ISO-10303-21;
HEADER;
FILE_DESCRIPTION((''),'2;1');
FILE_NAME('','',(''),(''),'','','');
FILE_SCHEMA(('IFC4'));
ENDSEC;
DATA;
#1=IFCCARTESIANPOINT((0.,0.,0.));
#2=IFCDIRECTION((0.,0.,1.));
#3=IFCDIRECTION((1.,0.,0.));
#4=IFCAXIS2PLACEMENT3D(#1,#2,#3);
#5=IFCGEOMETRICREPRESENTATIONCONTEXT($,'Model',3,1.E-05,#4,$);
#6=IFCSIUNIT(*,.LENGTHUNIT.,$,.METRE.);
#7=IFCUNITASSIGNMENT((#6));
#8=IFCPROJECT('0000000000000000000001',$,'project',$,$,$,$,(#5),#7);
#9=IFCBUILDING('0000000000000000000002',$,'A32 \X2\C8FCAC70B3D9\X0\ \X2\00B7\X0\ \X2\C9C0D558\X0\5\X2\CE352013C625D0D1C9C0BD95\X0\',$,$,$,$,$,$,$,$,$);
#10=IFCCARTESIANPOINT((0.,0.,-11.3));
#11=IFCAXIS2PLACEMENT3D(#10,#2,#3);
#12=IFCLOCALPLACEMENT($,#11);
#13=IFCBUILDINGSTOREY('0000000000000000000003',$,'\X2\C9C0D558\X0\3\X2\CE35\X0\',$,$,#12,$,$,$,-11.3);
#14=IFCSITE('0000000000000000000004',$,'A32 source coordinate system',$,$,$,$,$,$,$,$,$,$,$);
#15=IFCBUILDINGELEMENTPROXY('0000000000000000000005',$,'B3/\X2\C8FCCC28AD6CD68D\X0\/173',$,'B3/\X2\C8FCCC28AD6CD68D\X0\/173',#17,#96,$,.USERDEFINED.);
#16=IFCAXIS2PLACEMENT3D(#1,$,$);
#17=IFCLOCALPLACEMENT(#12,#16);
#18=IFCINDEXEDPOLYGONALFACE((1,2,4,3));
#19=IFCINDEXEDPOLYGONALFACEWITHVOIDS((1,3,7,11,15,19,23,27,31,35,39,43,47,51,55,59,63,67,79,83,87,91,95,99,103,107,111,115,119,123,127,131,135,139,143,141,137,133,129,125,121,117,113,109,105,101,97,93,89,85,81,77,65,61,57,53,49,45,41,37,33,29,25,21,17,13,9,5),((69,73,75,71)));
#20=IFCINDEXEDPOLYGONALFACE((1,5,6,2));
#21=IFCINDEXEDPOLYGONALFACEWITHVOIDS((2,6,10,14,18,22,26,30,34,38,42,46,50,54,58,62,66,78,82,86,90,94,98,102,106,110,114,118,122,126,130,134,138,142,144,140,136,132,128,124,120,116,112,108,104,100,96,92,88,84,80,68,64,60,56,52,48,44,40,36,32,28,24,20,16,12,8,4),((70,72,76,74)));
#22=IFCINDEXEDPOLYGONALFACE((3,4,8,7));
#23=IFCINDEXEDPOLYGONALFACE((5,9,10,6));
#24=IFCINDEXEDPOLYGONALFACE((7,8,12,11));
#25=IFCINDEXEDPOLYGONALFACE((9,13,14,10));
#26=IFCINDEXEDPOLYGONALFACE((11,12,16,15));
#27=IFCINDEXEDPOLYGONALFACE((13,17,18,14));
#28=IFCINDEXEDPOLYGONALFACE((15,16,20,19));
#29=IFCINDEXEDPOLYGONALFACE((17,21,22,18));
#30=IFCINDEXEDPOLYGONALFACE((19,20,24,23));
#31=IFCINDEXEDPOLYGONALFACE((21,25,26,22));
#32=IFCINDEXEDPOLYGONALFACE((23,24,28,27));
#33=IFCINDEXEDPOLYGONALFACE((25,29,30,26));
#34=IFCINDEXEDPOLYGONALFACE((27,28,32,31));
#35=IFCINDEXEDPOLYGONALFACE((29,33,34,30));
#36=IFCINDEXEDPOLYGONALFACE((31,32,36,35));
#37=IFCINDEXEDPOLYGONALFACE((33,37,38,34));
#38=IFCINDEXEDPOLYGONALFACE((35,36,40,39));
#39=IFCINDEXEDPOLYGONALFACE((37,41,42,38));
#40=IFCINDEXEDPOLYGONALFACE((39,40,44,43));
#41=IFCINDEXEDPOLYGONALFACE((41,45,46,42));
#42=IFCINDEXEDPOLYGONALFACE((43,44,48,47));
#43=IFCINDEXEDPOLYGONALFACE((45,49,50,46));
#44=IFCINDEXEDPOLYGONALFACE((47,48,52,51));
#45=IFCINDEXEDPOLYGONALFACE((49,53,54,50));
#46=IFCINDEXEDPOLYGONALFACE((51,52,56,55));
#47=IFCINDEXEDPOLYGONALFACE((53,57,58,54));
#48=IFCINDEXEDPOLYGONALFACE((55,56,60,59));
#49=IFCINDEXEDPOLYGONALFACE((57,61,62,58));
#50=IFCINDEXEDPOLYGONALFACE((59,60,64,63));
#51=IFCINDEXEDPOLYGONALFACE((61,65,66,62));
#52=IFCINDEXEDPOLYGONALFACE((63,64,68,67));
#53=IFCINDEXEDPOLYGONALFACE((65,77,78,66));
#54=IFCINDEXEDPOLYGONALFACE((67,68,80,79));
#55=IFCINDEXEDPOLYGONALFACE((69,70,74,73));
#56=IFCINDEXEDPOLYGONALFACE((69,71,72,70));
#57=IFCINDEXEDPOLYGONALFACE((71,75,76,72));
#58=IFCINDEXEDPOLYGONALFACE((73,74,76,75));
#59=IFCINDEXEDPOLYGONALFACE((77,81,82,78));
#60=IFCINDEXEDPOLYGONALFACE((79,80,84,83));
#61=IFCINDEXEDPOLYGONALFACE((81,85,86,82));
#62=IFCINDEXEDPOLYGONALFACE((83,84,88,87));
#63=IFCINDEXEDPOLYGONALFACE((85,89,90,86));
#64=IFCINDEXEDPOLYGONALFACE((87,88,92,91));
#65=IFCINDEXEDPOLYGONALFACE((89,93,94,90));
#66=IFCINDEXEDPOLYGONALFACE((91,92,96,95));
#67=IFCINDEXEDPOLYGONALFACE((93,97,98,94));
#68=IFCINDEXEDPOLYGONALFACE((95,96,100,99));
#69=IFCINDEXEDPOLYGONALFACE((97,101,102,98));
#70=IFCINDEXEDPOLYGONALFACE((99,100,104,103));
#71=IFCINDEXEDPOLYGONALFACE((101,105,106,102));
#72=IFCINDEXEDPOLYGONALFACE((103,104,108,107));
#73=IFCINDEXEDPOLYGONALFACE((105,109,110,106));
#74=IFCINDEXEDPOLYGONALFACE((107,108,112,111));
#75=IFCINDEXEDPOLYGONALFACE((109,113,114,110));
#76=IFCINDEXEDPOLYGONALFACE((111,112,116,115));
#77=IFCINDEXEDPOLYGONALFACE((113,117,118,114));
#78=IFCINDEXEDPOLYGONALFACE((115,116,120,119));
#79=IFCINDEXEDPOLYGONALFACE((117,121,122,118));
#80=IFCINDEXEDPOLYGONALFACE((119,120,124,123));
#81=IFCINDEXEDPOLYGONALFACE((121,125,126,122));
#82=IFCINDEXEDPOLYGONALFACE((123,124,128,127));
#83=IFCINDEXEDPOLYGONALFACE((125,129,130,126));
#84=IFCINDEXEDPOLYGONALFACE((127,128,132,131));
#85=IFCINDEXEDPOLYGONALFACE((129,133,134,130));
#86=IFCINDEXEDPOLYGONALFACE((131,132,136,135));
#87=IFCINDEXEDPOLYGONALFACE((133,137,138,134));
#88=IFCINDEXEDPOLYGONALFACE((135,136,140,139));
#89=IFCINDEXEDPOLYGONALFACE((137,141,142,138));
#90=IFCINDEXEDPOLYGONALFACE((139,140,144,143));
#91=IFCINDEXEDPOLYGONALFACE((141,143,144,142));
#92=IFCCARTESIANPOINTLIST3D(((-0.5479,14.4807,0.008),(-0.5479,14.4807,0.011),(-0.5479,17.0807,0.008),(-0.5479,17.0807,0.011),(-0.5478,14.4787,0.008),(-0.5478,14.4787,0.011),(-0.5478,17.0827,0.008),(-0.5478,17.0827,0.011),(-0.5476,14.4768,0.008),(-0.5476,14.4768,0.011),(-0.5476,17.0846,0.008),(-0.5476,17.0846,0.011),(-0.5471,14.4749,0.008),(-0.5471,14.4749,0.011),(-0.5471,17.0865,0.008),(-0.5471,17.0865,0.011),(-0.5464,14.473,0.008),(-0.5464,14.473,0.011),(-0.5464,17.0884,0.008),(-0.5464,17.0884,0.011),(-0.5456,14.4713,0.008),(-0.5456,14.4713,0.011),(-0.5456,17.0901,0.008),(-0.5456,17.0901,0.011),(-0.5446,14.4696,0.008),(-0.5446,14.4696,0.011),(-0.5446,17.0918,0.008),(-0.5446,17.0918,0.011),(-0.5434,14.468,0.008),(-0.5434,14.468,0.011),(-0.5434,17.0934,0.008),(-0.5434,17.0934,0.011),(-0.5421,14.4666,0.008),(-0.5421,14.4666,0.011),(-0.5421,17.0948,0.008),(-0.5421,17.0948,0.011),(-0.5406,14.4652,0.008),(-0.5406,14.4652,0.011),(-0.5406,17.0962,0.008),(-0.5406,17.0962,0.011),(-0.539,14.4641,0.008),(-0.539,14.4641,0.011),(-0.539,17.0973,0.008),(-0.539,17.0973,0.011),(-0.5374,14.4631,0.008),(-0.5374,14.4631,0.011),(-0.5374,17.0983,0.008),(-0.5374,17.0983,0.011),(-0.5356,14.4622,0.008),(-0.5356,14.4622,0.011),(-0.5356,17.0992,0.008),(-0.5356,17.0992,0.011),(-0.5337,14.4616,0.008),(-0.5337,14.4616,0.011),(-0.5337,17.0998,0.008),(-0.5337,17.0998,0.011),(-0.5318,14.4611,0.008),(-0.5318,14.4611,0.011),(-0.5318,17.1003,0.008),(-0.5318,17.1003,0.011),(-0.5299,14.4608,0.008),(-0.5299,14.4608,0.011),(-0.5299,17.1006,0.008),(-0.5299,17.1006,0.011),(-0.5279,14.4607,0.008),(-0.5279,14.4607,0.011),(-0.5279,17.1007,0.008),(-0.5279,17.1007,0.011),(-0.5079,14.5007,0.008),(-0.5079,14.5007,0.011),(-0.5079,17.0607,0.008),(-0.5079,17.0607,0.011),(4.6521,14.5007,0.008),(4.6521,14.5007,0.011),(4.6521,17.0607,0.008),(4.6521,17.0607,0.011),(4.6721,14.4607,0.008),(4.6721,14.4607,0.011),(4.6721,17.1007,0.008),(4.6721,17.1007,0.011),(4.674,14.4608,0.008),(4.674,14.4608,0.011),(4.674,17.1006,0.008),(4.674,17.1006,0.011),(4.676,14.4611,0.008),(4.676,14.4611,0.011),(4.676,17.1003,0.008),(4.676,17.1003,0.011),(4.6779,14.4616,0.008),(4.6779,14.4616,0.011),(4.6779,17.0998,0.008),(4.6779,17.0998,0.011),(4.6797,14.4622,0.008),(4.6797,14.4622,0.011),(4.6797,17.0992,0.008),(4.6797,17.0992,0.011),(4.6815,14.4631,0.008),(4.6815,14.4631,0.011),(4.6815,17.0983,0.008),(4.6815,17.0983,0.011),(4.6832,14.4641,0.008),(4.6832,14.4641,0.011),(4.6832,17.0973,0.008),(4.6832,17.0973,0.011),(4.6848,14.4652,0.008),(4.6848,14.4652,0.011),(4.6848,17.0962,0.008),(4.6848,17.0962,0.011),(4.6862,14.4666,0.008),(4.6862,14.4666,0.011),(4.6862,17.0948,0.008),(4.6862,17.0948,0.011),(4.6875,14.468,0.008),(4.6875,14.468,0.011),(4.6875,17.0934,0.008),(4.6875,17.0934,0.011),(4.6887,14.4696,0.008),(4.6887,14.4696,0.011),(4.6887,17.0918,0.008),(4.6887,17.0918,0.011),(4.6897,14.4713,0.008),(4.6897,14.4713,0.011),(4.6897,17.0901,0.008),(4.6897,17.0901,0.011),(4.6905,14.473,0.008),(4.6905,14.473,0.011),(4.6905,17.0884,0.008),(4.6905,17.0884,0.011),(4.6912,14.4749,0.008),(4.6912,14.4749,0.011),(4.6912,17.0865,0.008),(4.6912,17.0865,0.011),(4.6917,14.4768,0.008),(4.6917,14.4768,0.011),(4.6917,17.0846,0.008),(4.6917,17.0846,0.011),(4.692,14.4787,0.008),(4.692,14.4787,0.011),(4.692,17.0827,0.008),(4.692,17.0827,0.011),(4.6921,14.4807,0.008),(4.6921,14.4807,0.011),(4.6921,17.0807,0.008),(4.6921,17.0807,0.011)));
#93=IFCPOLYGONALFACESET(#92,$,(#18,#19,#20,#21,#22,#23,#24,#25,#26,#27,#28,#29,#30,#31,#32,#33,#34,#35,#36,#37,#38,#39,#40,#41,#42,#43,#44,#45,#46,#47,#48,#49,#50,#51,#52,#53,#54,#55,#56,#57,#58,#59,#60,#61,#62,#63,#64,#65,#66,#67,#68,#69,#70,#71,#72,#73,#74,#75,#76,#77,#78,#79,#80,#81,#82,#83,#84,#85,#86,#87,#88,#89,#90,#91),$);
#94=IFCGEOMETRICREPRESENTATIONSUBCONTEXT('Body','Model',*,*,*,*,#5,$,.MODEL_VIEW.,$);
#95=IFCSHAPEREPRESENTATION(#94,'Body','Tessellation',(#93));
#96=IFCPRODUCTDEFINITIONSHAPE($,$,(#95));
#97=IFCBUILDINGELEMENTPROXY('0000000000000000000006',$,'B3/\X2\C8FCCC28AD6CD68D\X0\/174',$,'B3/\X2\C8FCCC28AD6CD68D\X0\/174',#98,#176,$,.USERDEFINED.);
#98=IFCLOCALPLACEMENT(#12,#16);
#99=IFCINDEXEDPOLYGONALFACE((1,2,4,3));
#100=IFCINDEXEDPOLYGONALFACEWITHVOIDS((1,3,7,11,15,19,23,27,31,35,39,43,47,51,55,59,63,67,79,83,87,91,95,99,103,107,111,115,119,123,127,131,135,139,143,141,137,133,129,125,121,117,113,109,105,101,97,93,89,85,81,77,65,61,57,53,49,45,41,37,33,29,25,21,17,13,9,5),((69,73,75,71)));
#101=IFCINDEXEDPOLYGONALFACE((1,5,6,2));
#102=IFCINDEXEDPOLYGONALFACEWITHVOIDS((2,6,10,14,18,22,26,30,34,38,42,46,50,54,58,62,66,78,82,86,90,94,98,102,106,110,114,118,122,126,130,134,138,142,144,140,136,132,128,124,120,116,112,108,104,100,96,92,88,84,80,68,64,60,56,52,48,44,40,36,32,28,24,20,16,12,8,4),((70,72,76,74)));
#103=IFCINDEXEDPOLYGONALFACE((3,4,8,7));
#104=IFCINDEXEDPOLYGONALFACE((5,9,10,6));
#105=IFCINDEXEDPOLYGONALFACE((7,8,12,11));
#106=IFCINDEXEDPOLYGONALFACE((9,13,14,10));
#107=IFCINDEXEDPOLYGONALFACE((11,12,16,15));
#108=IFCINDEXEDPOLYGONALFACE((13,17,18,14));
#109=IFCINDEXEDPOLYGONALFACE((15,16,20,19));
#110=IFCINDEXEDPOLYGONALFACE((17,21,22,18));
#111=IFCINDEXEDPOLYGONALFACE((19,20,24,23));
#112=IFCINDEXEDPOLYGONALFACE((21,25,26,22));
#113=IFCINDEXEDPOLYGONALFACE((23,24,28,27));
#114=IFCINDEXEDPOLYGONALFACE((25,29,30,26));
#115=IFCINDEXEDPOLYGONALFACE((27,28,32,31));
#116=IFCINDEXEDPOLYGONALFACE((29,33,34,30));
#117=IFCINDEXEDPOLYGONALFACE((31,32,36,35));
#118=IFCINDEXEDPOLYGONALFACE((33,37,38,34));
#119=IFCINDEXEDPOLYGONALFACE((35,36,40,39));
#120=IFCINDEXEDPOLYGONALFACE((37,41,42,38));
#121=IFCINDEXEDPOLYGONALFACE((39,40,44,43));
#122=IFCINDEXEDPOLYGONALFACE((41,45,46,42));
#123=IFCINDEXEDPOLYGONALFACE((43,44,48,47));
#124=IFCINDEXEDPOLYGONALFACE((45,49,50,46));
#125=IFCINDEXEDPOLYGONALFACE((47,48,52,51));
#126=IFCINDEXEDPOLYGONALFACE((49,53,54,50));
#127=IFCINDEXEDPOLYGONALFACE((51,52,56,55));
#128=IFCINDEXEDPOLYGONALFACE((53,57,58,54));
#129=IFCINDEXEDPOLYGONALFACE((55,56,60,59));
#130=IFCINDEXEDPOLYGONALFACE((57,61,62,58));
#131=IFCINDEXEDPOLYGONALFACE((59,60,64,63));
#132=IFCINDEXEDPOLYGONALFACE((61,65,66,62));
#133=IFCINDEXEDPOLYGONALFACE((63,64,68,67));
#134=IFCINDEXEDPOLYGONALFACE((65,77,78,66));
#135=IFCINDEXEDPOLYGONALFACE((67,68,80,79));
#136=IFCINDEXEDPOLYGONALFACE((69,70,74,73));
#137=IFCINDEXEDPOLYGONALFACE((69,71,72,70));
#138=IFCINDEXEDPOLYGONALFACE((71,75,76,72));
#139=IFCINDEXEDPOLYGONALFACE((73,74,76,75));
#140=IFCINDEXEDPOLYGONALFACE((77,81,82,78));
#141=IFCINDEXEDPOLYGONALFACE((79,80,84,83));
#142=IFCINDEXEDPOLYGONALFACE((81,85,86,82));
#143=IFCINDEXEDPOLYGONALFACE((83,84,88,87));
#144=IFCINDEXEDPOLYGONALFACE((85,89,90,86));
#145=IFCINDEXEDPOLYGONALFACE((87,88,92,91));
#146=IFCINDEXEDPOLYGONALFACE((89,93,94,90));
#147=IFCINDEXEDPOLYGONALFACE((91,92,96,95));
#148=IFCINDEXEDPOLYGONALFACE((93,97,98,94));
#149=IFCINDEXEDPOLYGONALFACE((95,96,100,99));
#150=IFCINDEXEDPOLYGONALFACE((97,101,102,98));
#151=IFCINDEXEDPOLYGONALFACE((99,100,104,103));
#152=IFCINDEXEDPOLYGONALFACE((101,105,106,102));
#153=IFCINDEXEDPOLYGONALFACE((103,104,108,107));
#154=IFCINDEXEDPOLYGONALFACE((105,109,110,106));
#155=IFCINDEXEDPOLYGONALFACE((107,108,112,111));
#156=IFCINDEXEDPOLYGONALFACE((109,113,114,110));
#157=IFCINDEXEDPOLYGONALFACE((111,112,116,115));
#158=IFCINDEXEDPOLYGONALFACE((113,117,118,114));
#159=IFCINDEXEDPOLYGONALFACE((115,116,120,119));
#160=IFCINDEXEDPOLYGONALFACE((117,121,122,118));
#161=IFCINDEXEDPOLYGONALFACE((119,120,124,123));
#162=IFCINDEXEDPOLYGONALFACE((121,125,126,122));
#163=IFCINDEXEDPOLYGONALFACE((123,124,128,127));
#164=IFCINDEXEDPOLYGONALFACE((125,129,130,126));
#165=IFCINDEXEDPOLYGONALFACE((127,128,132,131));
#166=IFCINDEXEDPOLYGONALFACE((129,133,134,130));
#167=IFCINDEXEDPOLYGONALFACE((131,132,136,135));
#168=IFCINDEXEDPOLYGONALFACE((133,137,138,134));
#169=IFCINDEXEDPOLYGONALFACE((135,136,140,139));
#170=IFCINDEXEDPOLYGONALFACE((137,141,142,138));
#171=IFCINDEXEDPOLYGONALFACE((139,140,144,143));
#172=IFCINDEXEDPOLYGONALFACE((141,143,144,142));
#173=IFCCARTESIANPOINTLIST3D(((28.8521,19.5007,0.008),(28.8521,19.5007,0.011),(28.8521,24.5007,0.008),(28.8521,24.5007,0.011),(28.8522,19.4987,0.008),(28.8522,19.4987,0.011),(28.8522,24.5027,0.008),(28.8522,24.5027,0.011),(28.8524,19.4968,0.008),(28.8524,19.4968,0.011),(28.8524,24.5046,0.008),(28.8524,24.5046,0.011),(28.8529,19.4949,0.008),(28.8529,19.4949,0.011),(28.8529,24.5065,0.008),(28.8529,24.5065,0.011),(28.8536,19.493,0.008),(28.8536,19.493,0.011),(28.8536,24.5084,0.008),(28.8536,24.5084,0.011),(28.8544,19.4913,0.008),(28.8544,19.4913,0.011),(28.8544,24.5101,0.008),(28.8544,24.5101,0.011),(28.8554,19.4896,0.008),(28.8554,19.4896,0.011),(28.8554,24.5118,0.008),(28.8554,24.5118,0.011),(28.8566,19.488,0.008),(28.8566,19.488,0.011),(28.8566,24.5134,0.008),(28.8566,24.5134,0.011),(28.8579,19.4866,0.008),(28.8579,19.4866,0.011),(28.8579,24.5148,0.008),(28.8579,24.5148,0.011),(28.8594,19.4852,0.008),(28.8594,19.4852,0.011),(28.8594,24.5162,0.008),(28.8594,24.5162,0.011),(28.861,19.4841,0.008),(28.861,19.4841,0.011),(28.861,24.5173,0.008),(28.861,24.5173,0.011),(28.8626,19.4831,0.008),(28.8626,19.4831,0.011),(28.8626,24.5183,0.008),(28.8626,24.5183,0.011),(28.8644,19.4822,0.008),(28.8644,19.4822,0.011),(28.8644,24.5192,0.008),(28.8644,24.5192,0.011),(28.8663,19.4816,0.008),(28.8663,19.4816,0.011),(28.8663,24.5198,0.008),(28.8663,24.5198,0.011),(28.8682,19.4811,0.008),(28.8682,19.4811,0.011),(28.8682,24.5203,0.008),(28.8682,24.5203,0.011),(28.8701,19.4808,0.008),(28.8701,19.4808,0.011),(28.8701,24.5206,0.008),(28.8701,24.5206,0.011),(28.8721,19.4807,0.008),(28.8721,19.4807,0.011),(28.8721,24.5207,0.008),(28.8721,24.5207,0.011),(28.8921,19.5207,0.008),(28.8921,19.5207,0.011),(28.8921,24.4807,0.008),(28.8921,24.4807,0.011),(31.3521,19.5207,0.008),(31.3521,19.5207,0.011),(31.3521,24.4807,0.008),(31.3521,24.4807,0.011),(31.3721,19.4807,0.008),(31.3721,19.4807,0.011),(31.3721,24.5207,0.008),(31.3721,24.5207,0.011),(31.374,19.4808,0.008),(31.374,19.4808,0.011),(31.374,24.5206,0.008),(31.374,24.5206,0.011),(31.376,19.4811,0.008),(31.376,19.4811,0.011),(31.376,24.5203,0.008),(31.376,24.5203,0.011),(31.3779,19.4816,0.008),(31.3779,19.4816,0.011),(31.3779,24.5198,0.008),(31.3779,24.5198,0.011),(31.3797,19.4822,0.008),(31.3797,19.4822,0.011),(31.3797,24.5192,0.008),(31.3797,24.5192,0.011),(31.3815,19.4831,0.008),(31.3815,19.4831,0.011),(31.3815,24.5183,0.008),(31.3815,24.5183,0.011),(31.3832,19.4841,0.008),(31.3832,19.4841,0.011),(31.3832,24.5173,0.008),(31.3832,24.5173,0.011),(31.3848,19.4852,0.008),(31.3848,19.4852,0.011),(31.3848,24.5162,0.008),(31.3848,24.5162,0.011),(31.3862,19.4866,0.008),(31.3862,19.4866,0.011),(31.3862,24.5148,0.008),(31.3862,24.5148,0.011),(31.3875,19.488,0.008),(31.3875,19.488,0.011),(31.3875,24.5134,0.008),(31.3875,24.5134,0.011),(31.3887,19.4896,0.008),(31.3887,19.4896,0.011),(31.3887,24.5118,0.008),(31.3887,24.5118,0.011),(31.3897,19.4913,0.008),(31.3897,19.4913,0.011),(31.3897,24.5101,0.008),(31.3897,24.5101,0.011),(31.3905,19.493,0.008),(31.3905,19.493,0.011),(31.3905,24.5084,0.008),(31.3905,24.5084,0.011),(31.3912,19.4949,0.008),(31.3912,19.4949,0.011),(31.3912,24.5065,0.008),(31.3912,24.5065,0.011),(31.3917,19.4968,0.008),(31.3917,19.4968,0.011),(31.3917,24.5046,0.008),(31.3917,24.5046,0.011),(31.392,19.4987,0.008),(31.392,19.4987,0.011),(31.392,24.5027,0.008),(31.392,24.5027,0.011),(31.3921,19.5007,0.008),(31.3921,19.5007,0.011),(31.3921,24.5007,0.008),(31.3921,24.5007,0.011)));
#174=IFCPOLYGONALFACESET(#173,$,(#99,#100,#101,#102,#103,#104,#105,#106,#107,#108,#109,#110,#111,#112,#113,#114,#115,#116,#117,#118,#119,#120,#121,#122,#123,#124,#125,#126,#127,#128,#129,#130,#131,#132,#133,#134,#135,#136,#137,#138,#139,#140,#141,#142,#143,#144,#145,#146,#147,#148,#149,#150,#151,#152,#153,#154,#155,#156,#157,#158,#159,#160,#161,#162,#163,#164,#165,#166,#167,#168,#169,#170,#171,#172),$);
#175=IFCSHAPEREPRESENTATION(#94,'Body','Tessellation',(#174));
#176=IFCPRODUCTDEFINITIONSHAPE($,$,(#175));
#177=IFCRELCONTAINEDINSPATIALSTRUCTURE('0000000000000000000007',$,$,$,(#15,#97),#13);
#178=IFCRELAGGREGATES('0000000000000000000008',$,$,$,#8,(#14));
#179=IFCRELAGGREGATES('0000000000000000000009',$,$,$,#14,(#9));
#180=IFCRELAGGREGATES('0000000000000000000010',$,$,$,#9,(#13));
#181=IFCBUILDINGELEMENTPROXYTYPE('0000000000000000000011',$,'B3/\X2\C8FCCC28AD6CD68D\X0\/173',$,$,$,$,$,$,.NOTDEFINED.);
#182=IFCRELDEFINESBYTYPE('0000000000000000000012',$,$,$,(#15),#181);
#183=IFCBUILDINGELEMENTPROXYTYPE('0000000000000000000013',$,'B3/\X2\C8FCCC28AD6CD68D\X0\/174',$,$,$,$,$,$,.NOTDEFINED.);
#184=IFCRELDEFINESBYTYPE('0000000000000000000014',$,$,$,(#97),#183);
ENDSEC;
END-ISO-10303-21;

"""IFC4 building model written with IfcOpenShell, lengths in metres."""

from ifc_helpers import new_model, si_unit, frame, origin, origin_with_axes, place, context, subcontext, project, spatial, polyline, outline, extrude, source, transform, mapped, type_object, type_shapes, element, save


model = new_model("IFC4")

# Units and contexts
model_context = context("Model", 3, precision=1e-05, world=origin_with_axes())
body_context = subcontext(model_context, "Body", "Model", "MODEL_VIEW")
ifc_project = project(units=[si_unit("LENGTHUNIT", "METRE")], contexts=[model_context])

# Site, building, storey
site = spatial("IfcSite", under=ifc_project, Name="A32 source coordinate system")
building = spatial("IfcBuilding", under=site, Name="A32 주거동 · 지하5층–옥탑지붕")
storey_placement = place(None, frame((0.0, 0.0, -11.3), z_axis=(0.0, 0.0, 1.0), x_axis=(1.0, 0.0, 0.0)))
storey = spatial("IfcBuildingStorey", under=building, at=storey_placement, Name="지하3층", Elevation=-11.3)

# Building element proxies
building_element_proxy_type_1 = type_object("IfcBuildingElementProxyType", Name="B3/주차구획/173", PredefinedType="NOTDEFINED")
shared_shape_1 = source(origin(), body_context, "Body", "SweptSolid", [
    extrude(outline(polyline([(-0.5279, 14.4607), (-0.5299, 14.4608), (-0.5318, 14.4611), (-0.5337, 14.4616), (-0.5356, 14.4622), (-0.5374, 14.4631), (-0.539, 14.4641), (-0.5406, 14.4652), (-0.5421, 14.4666), (-0.5434, 14.468), (-0.5446, 14.4696), (-0.5456, 14.4713), (-0.5464, 14.473), (-0.5471, 14.4749), (-0.5476, 14.4768), (-0.5478, 14.4787), (-0.5479, 14.4807), (-0.5479, 17.0807), (-0.5478, 17.0827), (-0.5476, 17.0846), (-0.5471, 17.0865), (-0.5464, 17.0884), (-0.5456, 17.0901), (-0.5446, 17.0918), (-0.5434, 17.0934), (-0.5421, 17.0948), (-0.5406, 17.0962), (-0.539, 17.0973), (-0.5374, 17.0983), (-0.5356, 17.0992), (-0.5337, 17.0998), (-0.5318, 17.1003), (-0.5299, 17.1006), (-0.5279, 17.1007), (4.6721, 17.1007), (4.674, 17.1006), (4.676, 17.1003), (4.6779, 17.0998), (4.6797, 17.0992), (4.6815, 17.0983), (4.6832, 17.0973), (4.6848, 17.0962), (4.6862, 17.0948), (4.6875, 17.0934), (4.6887, 17.0918), (4.6897, 17.0901), (4.6905, 17.0884), (4.6912, 17.0865), (4.6917, 17.0846), (4.692, 17.0827), (4.6921, 17.0807), (4.6921, 14.4807), (4.692, 14.4787), (4.6917, 14.4768), (4.6912, 14.4749), (4.6905, 14.473), (4.6897, 14.4713), (4.6887, 14.4696), (4.6875, 14.468), (4.6862, 14.4666), (4.6848, 14.4652), (4.6832, 14.4641), (4.6815, 14.4631), (4.6797, 14.4622), (4.6779, 14.4616), (4.676, 14.4611), (4.674, 14.4608), (4.6721, 14.4607), (-0.5279, 14.4607)]), holes=[polyline([(-0.5079, 14.5007), (4.6521, 14.5007), (4.6521, 17.0607), (-0.5079, 17.0607), (-0.5079, 14.5007)])]), frame((0.0, 0.0, 0.008)), (0.0, 0.0, 1.0), 0.003),
])
type_shapes(building_element_proxy_type_1, [shared_shape_1])
proxy_1_placement = place(storey_placement, origin_with_axes())
element("IfcBuildingElementProxy", 1, at=proxy_1_placement, inside=storey, type_object=building_element_proxy_type_1, Name="B3/주차구획/173", ObjectType="B3/주차구획/173", PredefinedType="USERDEFINED", context=body_context, shape_type="MappedRepresentation", body=[
    mapped(shared_shape_1, transform((0.0, 0.0, 0.0), scale=1.0)),
])
building_element_proxy_type_2 = type_object("IfcBuildingElementProxyType", Name="B3/주차구획/174", PredefinedType="NOTDEFINED")
shared_shape_2 = source(origin(), body_context, "Body", "SweptSolid", [
    extrude(outline(polyline([(31.3921, 19.5007), (31.392, 19.4987), (31.3917, 19.4968), (31.3912, 19.4949), (31.3905, 19.493), (31.3897, 19.4913), (31.3887, 19.4896), (31.3875, 19.488), (31.3862, 19.4866), (31.3848, 19.4852), (31.3832, 19.4841), (31.3815, 19.4831), (31.3797, 19.4822), (31.3779, 19.4816), (31.376, 19.4811), (31.374, 19.4808), (31.3721, 19.4807), (28.8721, 19.4807), (28.8701, 19.4808), (28.8682, 19.4811), (28.8663, 19.4816), (28.8644, 19.4822), (28.8626, 19.4831), (28.861, 19.4841), (28.8594, 19.4852), (28.8579, 19.4866), (28.8566, 19.488), (28.8554, 19.4896), (28.8544, 19.4913), (28.8536, 19.493), (28.8529, 19.4949), (28.8524, 19.4968), (28.8522, 19.4987), (28.8521, 19.5007), (28.8521, 24.5007), (28.8522, 24.5027), (28.8524, 24.5046), (28.8529, 24.5065), (28.8536, 24.5084), (28.8544, 24.5101), (28.8554, 24.5118), (28.8566, 24.5134), (28.8579, 24.5148), (28.8594, 24.5162), (28.861, 24.5173), (28.8626, 24.5183), (28.8644, 24.5192), (28.8663, 24.5198), (28.8682, 24.5203), (28.8701, 24.5206), (28.8721, 24.5207), (31.3721, 24.5207), (31.374, 24.5206), (31.376, 24.5203), (31.3779, 24.5198), (31.3797, 24.5192), (31.3815, 24.5183), (31.3832, 24.5173), (31.3848, 24.5162), (31.3862, 24.5148), (31.3875, 24.5134), (31.3887, 24.5118), (31.3897, 24.5101), (31.3905, 24.5084), (31.3912, 24.5065), (31.3917, 24.5046), (31.392, 24.5027), (31.3921, 24.5007), (31.3921, 19.5007)]), holes=[polyline([(31.3521, 19.5207), (31.3521, 24.4807), (28.8921, 24.4807), (28.8921, 19.5207), (31.3521, 19.5207)])]), frame((0.0, 0.0, 0.008)), (0.0, 0.0, 1.0), 0.003),
])
type_shapes(building_element_proxy_type_2, [shared_shape_2])
proxy_2_placement = place(storey_placement, origin_with_axes())
element("IfcBuildingElementProxy", 2, at=proxy_2_placement, inside=storey, type_object=building_element_proxy_type_2, Name="B3/주차구획/174", ObjectType="B3/주차구획/174", PredefinedType="USERDEFINED", context=body_context, shape_type="MappedRepresentation", body=[
    mapped(shared_shape_2, transform((0.0, 0.0, 0.0), scale=1.0)),
])

save(model, "model.ifc")
